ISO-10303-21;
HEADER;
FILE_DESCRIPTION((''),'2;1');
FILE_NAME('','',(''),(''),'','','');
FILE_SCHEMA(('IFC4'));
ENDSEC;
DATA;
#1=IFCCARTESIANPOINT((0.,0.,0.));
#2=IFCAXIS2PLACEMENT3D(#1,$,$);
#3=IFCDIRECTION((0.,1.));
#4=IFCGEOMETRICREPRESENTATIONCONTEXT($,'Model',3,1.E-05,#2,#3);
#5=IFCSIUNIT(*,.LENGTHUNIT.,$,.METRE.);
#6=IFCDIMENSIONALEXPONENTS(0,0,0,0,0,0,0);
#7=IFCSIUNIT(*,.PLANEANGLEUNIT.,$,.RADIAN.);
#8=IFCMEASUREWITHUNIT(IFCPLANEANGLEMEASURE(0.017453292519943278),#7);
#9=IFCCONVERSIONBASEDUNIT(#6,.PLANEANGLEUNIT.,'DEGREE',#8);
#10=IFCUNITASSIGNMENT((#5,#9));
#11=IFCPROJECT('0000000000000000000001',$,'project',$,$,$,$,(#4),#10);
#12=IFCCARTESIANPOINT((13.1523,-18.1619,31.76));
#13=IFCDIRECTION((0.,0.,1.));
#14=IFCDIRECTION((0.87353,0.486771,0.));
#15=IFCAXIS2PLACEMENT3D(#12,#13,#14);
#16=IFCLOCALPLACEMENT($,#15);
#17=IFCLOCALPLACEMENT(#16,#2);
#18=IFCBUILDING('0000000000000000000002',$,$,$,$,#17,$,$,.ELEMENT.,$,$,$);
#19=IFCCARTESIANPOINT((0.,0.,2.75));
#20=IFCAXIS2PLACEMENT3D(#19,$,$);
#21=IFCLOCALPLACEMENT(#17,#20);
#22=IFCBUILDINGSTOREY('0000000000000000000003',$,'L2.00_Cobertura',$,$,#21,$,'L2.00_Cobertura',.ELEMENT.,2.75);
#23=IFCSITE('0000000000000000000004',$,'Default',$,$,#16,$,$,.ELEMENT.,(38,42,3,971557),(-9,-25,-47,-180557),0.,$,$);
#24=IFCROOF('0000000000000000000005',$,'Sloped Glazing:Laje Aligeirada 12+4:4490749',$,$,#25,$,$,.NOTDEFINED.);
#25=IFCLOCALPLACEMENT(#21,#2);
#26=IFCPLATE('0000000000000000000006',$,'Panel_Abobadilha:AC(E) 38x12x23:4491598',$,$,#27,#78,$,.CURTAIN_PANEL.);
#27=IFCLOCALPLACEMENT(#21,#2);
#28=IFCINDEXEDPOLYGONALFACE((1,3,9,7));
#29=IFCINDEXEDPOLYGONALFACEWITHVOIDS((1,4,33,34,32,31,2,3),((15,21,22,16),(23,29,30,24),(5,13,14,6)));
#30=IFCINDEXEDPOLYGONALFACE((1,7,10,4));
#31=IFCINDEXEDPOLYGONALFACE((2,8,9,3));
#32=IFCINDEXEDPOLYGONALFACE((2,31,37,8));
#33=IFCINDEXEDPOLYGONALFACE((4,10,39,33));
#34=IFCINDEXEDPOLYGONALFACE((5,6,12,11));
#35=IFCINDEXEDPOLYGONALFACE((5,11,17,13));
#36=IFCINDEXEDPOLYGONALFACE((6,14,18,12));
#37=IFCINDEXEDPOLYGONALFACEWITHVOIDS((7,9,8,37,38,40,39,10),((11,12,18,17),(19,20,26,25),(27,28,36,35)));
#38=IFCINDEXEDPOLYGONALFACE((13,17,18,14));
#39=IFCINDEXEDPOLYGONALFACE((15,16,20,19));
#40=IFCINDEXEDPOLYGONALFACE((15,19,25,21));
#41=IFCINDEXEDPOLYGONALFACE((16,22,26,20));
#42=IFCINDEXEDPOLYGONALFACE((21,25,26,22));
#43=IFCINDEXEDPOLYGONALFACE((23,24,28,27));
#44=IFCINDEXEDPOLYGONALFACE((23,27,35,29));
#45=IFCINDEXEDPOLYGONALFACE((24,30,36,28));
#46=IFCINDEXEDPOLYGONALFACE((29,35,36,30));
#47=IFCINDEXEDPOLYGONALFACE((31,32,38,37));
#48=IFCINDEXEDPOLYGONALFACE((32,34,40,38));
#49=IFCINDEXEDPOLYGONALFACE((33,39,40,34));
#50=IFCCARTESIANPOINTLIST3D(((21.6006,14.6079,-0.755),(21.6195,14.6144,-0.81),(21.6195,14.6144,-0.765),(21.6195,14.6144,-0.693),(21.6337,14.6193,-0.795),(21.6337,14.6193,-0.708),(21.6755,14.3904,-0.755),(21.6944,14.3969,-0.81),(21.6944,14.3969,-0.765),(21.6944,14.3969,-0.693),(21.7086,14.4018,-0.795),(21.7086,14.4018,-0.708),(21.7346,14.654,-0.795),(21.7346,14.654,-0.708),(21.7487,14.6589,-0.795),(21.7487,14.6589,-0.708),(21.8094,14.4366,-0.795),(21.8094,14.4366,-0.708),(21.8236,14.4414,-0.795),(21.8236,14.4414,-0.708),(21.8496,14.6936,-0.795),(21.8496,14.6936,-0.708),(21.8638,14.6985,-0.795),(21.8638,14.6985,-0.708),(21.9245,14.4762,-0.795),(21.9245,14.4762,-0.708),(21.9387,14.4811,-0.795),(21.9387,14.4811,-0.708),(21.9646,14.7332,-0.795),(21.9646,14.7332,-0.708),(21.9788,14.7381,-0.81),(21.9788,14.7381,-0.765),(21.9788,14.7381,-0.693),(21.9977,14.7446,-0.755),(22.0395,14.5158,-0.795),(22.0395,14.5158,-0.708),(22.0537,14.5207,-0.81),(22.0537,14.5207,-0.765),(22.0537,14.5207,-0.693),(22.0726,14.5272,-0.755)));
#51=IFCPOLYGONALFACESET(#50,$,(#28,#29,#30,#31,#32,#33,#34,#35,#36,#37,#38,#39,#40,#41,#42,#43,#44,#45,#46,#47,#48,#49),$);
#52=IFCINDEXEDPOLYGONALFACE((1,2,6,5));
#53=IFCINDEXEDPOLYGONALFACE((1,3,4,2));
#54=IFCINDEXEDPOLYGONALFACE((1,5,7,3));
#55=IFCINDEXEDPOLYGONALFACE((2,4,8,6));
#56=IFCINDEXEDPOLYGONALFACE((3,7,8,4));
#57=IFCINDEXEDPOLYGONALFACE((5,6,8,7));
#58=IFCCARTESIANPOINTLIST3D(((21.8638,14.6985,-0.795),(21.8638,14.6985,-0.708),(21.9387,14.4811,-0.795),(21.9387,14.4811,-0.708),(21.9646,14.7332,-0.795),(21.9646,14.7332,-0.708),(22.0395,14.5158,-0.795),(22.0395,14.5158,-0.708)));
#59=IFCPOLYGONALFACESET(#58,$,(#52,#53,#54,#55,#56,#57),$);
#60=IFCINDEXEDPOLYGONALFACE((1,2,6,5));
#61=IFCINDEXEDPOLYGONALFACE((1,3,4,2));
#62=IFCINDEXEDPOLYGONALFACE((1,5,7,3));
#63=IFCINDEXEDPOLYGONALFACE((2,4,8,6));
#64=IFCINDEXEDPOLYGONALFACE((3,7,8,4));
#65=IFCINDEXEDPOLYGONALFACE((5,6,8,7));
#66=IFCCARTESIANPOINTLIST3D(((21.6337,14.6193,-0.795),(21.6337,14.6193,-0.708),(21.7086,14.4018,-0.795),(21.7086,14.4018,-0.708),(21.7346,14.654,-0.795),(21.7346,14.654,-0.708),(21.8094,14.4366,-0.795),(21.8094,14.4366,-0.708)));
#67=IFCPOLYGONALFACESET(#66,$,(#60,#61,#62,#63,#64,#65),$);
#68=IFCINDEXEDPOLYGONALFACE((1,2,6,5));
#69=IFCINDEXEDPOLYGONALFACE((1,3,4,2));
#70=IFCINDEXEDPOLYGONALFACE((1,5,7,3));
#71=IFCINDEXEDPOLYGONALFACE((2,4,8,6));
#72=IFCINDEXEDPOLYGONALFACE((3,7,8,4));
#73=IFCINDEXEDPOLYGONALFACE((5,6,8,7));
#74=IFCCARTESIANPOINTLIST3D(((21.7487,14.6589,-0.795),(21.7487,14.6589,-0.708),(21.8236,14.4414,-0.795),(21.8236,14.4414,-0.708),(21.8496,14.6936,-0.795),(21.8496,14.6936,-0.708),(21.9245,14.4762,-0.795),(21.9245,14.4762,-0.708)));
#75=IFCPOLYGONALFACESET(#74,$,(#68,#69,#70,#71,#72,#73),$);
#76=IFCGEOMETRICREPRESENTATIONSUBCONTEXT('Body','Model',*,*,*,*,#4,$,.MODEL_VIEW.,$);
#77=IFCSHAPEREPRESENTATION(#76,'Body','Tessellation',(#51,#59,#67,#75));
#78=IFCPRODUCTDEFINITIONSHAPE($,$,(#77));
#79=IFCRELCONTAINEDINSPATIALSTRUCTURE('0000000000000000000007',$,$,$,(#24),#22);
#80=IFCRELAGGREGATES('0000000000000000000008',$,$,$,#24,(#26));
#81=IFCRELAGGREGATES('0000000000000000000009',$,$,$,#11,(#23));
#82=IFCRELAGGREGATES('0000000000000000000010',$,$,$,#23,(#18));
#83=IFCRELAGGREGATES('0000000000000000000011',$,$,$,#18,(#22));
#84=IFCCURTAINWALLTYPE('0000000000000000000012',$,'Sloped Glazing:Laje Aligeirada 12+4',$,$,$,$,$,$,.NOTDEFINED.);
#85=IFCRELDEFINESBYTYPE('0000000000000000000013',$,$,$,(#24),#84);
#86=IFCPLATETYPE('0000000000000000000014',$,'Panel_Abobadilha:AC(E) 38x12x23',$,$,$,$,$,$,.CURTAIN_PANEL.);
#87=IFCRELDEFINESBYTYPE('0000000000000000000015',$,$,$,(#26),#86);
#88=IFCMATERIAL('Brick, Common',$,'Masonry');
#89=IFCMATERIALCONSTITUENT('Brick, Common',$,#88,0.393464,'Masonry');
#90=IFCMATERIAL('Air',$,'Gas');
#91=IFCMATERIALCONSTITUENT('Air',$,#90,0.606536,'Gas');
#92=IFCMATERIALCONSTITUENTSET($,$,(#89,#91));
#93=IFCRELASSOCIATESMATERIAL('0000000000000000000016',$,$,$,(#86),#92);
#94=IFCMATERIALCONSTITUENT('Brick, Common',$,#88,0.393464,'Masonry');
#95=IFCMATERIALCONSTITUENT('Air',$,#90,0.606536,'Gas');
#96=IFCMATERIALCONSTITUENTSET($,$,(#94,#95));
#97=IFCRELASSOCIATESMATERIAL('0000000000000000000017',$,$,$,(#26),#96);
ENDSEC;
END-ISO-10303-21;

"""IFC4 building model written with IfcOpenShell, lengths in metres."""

from ifc_helpers import new_model, entity, si_unit, converted_unit, direction, frame, origin, place, context, subcontext, project, spatial, indexed_curve, outline, extrude, source, transform, mapped, material, constituent, constituent_set, type_object, type_shapes, element, aggregate, save


model = new_model("IFC4")

# Units and contexts
model_context = context("Model", 3, precision=1e-05, world=origin(), true_north=direction((0.0, 1.0)))
body_context = subcontext(model_context, "Body", "Model", "MODEL_VIEW")
ifc_project = project(units=[si_unit("LENGTHUNIT", "METRE"), converted_unit("PLANEANGLEUNIT", "DEGREE", entity("IfcPlaneAngleMeasure", 0.017453292519943278), si_unit("PLANEANGLEUNIT", "RADIAN"), dimensions=[0, 0, 0, 0, 0, 0, 0])], contexts=[model_context])

# Site, building, storey
site_placement = place(None, frame((13.1523, -18.1619, 31.76), z_axis=(0.0, 0.0, 1.0), x_axis=(0.87353, 0.486771, 0.0)))
site = spatial("IfcSite", under=ifc_project, at=site_placement, Name="Default", CompositionType="ELEMENT", RefLatitude=(38, 42, 3, 971557), RefLongitude=(-9, -25, -47, -180557), RefElevation=0.0)
building_placement = place(site_placement, origin())
building = spatial("IfcBuilding", under=site, at=building_placement, CompositionType="ELEMENT")
storey_placement = place(building_placement, frame((0.0, 0.0, 2.75)))
storey = spatial("IfcBuildingStorey", under=building, at=storey_placement, Name="L2.00_Cobertura", LongName="L2.00_Cobertura", CompositionType="ELEMENT", Elevation=2.75)

# Roof, plate
curtain_wall_type = type_object("IfcCurtainWallType", Name="Sloped Glazing:Laje Aligeirada 12+4", PredefinedType="NOTDEFINED")
roof_placement = place(storey_placement, frame((0.0, 0.0, -2.75)))
roof = element("IfcRoof", 1, at=roof_placement, inside=storey, type_object=curtain_wall_type, Name="Sloped Glazing:Laje Aligeirada 12+4:4490749", PredefinedType="NOTDEFINED")
ifc_material_1 = material(Name="Brick, Common", Category="Masonry")
ifc_material_2 = material(Name="Air", Category="Gas")
ifc_constituent_1 = constituent(ifc_material_1, Name="Brick, Common", Category="Masonry", fraction=0.393464)
ifc_constituent_2 = constituent(ifc_material_2, Name="Air", Category="Gas", fraction=0.606536)
ifc_constituent_set_1 = constituent_set(constituents=[ifc_constituent_1, ifc_constituent_2])
plate_type = type_object("IfcPlateType", Name="Panel_Abobadilha:AC(E) 38x12x23", PredefinedType="CURTAIN_PANEL", material=ifc_constituent_set_1)
shared_shape_1 = source(origin(), body_context, "Body", "SweptSolid", [
    extrude(outline(indexed_curve([(-0.19, -0.0543), (0.19, -0.0543), (0.19, -0.0093), (0.21, 0.0007), (0.19, 0.0628), (-0.19, 0.0628), (-0.21, 0.0007), (-0.19, -0.0093), (-0.19, -0.0543)], self_intersect=False), holes=[indexed_curve([(-0.0683, 0.0477), (-0.0683, -0.0393), (-0.175, -0.0393), (-0.175, 0.0477), (-0.0683, 0.0477)], self_intersect=False), indexed_curve([(0.0533, 0.0477), (0.0533, -0.0393), (-0.0533, -0.0393), (-0.0533, 0.0477), (0.0533, 0.0477)], self_intersect=False), indexed_curve([(0.175, 0.0477), (0.175, -0.0393), (0.0683, -0.0393), (0.0683, 0.0477), (0.175, 0.0477)], self_intersect=False)]), frame((0.0, 0.0543, 0.0)), (0.0, 0.0, 1.0), 0.23),
    extrude(outline(indexed_curve([(-0.0533, -0.0435), (0.0533, -0.0435), (0.0533, 0.0435), (-0.0533, 0.0435), (-0.0533, -0.0435)], self_intersect=False)), frame((0.1217, 0.0585, 0.0), z_axis=(0.0, 0.0, 1.0), x_axis=(-1.0, 0.0, 0.0)), (0.0, 0.0, 1.0), 0.23),
    extrude(outline(indexed_curve([(-0.0533, -0.0435), (0.0533, -0.0435), (0.0533, 0.0435), (-0.0533, 0.0435), (-0.0533, -0.0435)], self_intersect=False)), frame((-0.1217, 0.0585, 0.0), z_axis=(0.0, 0.0, 1.0), x_axis=(-1.0, 0.0, 0.0)), (0.0, 0.0, 1.0), 0.23),
    extrude(outline(indexed_curve([(-0.0533, -0.0435), (0.0533, -0.0435), (0.0533, 0.0435), (-0.0533, 0.0435), (-0.0533, -0.0435)], self_intersect=False)), frame((0.0, 0.0585, 0.0), z_axis=(0.0, 0.0, 1.0), x_axis=(-1.0, 0.0, 0.0)), (0.0, 0.0, 1.0), 0.23),
])
type_shapes(plate_type, [shared_shape_1])
ifc_constituent_3 = constituent(ifc_material_1, Name="Brick, Common", Category="Masonry", fraction=0.393464)
ifc_constituent_4 = constituent(ifc_material_2, Name="Air", Category="Gas", fraction=0.606536)
ifc_constituent_set_2 = constituent_set(constituents=[ifc_constituent_3, ifc_constituent_4])
plate_1_placement = place(roof_placement, frame((21.7992, 14.6763, 1.94), z_axis=(0.325568, -0.945519, 0.0), x_axis=(0.945519, 0.325568, 0.0)))
plate_1 = element("IfcPlate", 2, at=plate_1_placement, type_object=plate_type, material=ifc_constituent_set_2, Name="Panel_Abobadilha:AC(E) 38x12x23:4491598", PredefinedType="CURTAIN_PANEL", context=body_context, shape_type="MappedRepresentation", body=[
    mapped(shared_shape_1, transform((0.0, 0.0, 0.0), scale=1.0)),
])
aggregate(roof, [plate_1])

save(model, "model.ifc")
